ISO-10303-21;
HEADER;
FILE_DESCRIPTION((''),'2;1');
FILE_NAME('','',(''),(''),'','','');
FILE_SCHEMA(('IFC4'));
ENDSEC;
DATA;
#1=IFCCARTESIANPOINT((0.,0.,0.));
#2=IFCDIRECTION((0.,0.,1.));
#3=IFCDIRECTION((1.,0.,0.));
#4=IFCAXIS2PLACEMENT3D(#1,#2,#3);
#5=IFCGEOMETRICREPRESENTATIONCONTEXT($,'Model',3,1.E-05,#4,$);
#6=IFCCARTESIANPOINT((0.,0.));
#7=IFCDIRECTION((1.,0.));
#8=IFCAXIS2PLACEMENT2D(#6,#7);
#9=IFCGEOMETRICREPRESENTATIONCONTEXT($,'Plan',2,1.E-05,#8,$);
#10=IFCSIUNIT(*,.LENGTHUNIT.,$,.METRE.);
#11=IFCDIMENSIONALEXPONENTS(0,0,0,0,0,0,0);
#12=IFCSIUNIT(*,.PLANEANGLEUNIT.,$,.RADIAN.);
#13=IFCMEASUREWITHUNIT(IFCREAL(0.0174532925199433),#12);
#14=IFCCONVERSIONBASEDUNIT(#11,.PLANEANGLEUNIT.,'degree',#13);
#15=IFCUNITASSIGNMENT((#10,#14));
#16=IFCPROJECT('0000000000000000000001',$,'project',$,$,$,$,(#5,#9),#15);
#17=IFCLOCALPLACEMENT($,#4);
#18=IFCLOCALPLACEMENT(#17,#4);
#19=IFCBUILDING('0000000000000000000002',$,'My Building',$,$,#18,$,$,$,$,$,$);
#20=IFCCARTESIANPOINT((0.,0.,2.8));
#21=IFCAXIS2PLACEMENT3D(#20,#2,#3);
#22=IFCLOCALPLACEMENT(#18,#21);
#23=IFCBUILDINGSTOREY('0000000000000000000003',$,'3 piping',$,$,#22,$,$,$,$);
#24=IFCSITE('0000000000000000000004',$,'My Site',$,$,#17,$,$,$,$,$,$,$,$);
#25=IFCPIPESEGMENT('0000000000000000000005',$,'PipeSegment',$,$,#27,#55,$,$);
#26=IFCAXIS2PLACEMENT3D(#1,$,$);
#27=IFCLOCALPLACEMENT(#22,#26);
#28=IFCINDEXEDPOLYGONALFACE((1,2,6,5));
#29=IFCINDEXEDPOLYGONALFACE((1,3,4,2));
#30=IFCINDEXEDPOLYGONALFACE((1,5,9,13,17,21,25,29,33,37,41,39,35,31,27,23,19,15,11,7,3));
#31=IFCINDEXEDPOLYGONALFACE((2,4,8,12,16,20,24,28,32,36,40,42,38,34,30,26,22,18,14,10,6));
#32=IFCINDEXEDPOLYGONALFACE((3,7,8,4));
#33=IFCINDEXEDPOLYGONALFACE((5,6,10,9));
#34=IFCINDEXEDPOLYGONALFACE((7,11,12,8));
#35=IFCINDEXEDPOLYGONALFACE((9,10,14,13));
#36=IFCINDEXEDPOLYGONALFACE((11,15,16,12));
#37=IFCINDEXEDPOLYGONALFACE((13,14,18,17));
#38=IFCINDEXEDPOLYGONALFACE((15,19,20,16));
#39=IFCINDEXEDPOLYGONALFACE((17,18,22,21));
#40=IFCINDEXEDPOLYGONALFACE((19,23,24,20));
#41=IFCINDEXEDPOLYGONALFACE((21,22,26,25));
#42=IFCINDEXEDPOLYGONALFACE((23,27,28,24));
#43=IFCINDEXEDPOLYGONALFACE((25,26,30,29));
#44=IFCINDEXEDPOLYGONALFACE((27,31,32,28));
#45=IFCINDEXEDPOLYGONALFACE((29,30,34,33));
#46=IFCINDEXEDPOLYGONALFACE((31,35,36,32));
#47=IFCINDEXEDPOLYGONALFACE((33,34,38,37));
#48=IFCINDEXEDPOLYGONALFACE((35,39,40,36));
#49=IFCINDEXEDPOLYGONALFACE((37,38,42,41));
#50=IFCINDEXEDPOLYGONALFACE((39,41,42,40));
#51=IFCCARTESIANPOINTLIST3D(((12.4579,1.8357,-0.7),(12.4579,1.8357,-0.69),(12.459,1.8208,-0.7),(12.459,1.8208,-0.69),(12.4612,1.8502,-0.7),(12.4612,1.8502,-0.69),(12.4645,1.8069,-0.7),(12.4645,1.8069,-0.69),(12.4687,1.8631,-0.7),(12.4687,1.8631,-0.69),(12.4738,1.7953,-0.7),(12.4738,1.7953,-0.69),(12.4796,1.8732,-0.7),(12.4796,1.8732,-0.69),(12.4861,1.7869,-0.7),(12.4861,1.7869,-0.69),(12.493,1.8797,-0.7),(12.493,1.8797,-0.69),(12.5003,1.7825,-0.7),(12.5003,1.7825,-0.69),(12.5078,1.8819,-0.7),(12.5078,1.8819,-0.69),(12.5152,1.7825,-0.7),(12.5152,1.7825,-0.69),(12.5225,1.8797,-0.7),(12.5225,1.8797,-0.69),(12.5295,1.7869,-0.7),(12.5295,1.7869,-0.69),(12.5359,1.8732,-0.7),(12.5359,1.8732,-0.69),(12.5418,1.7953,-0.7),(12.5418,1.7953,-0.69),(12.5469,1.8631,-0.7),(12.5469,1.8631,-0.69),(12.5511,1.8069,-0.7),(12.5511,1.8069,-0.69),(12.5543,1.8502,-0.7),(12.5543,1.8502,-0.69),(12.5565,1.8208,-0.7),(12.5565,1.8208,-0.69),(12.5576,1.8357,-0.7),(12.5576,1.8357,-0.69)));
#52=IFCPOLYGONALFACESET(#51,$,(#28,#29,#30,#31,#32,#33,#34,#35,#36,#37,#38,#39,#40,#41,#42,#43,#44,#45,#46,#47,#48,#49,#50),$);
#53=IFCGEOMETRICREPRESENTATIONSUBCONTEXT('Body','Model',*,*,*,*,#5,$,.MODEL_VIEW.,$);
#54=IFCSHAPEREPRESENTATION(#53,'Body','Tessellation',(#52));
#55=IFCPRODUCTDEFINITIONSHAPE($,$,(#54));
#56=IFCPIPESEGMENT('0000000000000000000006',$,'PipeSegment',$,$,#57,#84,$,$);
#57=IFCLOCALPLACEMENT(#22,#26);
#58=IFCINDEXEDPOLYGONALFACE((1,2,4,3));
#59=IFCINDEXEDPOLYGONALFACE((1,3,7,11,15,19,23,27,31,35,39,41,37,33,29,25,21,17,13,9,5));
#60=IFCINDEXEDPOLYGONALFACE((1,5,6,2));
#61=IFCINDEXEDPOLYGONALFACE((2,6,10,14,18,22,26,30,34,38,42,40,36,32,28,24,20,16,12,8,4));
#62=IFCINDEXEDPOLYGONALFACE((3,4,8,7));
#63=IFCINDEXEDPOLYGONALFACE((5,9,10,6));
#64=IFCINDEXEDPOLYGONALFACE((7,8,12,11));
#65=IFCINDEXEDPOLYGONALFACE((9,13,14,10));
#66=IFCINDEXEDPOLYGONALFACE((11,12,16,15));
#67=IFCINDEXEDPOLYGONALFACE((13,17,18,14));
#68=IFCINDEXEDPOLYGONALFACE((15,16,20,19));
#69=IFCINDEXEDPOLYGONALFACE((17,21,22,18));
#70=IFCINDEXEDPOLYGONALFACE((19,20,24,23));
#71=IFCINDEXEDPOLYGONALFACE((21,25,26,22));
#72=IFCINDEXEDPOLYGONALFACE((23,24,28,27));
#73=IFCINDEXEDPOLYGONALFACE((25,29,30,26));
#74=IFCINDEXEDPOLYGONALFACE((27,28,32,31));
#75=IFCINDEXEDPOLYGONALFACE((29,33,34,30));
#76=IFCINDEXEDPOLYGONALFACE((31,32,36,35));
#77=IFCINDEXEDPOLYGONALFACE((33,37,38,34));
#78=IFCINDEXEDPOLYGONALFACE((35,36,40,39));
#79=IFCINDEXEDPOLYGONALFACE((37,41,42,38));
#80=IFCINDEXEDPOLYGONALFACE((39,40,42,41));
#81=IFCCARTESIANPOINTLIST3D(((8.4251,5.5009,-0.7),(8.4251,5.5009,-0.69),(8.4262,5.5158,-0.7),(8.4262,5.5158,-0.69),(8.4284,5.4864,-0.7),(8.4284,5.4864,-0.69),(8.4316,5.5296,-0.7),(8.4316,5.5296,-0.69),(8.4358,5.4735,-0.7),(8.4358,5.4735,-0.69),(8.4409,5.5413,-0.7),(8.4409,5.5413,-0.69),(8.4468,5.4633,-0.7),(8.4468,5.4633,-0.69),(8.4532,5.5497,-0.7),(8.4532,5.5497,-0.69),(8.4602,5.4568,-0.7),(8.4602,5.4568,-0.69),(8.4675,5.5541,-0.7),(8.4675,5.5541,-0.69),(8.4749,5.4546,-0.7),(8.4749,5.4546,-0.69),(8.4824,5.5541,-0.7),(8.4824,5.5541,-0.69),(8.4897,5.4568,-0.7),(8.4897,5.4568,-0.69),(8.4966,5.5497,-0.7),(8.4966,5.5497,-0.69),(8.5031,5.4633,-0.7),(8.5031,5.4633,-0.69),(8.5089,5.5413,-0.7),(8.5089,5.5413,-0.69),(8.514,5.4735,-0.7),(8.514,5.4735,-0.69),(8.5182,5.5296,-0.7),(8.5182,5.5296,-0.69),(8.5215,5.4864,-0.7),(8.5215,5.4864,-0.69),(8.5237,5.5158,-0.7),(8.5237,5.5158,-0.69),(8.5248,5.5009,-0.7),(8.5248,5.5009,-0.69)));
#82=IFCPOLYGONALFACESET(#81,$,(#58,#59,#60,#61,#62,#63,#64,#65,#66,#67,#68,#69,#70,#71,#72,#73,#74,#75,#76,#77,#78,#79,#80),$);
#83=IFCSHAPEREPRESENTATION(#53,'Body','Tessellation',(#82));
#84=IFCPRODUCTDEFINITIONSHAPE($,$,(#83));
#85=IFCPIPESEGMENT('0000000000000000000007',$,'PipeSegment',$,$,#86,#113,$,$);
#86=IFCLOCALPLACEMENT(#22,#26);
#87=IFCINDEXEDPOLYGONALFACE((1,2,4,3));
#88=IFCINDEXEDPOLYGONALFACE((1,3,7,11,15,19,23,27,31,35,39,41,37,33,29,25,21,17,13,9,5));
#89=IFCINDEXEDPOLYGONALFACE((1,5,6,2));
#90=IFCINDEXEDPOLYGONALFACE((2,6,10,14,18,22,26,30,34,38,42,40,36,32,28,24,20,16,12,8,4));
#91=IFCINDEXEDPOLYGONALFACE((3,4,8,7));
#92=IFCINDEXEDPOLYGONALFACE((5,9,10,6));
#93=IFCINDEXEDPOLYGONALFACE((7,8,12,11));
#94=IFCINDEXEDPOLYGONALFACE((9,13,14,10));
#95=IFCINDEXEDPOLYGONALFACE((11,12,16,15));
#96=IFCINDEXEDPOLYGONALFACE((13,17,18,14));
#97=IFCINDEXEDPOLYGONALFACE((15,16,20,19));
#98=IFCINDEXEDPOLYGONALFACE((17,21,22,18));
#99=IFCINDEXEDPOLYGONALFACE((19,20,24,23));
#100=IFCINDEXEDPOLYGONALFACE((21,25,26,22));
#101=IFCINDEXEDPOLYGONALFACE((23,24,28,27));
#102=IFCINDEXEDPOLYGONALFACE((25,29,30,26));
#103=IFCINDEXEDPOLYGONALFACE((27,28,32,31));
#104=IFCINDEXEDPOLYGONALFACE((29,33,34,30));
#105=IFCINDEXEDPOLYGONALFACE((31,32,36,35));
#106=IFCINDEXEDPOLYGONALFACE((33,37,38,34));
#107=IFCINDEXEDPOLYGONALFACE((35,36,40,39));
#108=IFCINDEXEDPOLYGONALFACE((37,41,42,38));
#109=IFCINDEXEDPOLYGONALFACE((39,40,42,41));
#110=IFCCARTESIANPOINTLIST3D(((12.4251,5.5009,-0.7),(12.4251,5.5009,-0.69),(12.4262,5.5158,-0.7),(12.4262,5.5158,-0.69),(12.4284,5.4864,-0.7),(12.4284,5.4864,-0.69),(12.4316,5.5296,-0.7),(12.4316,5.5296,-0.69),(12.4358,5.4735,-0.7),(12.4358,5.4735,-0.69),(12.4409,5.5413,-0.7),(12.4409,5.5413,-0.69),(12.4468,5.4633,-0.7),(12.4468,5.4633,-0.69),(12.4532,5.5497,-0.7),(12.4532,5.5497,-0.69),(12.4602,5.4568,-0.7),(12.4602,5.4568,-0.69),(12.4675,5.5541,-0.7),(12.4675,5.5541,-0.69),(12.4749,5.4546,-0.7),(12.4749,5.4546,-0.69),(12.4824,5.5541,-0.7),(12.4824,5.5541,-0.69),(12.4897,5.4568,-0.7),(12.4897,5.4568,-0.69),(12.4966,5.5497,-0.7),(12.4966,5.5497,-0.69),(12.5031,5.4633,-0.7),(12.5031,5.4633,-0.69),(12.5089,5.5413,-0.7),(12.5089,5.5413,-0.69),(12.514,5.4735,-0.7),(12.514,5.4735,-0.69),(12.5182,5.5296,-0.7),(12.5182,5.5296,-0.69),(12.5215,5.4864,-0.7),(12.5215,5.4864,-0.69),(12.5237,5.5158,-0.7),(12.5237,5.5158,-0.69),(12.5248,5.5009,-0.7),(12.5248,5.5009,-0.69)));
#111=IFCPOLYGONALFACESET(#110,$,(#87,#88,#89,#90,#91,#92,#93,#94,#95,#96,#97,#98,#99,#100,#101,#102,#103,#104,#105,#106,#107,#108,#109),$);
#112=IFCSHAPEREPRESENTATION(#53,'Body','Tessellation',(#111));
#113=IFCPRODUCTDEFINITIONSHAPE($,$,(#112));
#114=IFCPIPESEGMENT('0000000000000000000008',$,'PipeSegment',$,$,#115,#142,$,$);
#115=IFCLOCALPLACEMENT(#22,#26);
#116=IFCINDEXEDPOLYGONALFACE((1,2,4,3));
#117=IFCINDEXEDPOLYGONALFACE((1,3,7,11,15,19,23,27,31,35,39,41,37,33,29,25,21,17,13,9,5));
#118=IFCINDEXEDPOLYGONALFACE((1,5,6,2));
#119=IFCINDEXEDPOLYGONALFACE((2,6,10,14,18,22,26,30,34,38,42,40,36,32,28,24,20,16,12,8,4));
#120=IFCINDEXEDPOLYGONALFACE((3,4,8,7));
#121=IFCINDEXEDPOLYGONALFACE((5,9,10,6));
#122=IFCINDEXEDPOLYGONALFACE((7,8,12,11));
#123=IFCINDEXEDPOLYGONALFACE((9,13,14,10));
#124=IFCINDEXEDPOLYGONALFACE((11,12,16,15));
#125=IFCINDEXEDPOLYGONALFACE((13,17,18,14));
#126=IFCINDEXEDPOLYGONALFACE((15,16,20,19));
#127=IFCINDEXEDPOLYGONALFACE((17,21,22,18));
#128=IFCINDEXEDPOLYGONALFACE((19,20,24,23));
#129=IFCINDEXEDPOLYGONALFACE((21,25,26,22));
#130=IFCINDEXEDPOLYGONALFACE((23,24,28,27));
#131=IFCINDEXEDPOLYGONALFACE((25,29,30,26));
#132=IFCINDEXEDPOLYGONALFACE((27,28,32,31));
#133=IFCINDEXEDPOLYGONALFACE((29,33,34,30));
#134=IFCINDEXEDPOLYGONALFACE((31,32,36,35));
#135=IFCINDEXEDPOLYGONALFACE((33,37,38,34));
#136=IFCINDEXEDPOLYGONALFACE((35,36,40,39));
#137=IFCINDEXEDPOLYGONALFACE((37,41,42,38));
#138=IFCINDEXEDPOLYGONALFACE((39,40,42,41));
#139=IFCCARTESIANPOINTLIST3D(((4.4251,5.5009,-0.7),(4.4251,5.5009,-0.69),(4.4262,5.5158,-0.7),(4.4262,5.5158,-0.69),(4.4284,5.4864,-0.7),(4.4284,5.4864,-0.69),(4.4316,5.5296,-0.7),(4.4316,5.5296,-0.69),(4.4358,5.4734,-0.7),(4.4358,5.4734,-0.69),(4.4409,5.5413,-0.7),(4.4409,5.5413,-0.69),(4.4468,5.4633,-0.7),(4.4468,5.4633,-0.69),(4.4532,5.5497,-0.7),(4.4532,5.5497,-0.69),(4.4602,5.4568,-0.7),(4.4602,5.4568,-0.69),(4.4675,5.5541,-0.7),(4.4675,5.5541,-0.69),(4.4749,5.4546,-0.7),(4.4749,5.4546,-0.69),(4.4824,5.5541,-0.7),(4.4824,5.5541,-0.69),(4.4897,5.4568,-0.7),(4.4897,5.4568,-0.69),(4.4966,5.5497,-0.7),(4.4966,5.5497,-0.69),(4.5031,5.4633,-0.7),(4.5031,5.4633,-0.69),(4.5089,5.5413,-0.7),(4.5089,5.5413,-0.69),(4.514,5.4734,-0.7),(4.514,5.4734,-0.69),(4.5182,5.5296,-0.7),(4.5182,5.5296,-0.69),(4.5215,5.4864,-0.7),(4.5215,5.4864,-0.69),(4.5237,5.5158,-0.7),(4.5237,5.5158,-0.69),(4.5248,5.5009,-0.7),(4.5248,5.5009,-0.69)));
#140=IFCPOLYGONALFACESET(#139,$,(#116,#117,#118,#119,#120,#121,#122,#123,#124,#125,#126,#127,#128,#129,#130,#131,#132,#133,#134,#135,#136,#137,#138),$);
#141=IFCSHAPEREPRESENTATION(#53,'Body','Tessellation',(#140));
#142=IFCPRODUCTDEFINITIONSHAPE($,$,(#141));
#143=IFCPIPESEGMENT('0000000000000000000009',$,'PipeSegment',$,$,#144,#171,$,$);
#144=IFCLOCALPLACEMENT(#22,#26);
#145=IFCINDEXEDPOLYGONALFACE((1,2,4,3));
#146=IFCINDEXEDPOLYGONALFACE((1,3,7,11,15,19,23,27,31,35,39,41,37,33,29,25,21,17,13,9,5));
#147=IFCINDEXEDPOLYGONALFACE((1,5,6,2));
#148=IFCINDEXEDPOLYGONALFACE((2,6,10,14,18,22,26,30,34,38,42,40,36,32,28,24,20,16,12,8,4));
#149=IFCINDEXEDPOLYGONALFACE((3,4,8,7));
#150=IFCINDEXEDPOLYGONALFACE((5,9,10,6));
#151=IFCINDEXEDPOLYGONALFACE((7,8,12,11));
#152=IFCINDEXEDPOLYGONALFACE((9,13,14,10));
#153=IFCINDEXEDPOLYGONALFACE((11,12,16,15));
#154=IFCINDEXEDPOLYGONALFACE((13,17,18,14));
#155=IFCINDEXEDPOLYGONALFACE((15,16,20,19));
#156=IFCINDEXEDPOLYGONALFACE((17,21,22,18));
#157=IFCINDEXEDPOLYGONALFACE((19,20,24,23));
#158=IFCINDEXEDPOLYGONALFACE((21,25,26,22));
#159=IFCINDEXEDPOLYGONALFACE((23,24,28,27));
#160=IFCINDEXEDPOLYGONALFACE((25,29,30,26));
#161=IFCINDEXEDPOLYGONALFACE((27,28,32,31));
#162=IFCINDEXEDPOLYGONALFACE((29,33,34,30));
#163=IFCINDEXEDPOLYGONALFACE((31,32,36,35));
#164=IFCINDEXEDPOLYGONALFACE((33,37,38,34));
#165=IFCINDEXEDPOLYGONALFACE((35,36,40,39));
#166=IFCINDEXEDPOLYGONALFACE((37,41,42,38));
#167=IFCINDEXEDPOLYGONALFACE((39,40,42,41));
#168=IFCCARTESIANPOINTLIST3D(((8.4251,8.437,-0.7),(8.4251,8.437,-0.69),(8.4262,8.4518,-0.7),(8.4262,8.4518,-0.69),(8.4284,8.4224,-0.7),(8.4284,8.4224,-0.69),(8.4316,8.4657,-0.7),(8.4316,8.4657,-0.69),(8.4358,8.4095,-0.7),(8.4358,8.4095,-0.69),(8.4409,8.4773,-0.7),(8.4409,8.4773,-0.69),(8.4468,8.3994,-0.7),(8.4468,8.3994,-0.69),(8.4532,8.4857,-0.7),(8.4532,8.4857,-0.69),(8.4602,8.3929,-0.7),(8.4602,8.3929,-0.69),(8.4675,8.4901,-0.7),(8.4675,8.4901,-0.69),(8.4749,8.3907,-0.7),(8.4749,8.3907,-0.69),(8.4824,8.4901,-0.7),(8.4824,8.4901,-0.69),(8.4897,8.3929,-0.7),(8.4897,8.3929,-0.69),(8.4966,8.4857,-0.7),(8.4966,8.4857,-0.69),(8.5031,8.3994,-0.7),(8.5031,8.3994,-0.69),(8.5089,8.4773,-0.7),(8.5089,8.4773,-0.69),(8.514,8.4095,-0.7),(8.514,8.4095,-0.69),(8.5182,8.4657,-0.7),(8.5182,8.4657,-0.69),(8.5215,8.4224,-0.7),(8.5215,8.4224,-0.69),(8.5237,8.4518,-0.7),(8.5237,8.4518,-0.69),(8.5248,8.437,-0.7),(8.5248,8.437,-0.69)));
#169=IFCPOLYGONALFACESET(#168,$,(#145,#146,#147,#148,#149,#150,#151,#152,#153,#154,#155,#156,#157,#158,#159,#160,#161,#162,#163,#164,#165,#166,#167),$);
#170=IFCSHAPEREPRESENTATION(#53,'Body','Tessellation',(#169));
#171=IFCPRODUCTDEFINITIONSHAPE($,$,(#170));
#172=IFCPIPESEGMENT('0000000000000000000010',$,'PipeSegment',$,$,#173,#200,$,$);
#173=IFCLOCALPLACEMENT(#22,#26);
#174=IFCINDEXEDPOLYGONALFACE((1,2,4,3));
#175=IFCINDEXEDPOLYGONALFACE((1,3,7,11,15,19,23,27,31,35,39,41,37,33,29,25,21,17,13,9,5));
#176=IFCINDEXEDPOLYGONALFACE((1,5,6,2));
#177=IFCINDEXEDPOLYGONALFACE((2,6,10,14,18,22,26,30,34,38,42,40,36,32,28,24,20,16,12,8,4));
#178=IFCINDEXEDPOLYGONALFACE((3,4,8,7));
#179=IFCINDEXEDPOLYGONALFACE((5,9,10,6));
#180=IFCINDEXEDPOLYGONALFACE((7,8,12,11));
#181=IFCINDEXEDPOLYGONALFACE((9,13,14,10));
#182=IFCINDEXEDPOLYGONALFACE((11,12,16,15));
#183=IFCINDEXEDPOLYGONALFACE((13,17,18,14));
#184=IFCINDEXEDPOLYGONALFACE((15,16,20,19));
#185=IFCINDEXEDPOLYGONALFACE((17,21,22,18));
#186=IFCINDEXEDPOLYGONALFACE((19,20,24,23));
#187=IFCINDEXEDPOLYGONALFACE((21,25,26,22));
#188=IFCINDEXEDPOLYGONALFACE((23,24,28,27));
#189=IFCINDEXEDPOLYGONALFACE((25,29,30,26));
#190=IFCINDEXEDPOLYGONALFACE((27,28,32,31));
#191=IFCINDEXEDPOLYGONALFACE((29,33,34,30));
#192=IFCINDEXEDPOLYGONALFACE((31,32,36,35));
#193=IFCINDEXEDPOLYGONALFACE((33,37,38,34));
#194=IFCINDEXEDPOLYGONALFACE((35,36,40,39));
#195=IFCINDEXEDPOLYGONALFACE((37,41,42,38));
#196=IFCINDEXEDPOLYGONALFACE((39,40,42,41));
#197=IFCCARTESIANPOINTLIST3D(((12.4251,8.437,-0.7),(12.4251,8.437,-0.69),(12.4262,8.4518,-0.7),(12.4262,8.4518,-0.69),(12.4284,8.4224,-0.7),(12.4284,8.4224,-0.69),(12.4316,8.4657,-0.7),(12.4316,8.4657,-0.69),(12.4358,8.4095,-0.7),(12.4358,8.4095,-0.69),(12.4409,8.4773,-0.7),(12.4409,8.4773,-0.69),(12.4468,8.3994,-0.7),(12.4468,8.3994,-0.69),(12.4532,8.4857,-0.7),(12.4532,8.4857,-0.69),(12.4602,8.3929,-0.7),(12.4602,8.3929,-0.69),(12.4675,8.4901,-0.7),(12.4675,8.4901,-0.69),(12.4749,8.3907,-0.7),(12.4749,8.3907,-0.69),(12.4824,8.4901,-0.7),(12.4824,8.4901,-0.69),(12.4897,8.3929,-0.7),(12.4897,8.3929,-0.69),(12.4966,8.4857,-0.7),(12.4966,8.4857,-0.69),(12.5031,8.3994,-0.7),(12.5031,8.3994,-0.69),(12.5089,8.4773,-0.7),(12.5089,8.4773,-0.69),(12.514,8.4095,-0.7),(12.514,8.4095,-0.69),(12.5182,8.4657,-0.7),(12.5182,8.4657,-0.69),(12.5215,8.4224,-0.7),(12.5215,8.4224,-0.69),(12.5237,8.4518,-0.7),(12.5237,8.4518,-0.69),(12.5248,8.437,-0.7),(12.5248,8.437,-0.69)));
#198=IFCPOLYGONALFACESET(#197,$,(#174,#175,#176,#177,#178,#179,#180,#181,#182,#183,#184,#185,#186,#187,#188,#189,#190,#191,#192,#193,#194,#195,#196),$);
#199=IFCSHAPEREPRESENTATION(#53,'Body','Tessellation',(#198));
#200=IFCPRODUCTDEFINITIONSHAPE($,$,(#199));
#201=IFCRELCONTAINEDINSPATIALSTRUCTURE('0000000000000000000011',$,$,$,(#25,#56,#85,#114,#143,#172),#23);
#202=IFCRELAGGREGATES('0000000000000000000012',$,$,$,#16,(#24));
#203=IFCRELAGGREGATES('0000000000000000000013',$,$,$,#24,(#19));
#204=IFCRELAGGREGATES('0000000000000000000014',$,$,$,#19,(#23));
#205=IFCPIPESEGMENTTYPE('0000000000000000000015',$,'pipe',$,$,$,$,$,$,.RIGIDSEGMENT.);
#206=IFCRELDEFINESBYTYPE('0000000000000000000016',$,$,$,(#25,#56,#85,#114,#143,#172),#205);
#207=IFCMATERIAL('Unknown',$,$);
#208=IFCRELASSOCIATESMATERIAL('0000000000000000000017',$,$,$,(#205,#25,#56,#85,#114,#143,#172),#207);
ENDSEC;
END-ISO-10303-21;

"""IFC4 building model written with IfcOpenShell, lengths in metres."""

from ifc_helpers import new_model, entity, si_unit, converted_unit, frame, origin_with_axes, origin_2d_with_axis, place, context, subcontext, project, spatial, circle, extrude, material, material_profile, profile_set, profile_usage, type_object, element, save


model = new_model("IFC4")

# Units and contexts
model_context = context("Model", 3, precision=1e-05, world=origin_with_axes())
plan_context = context("Plan", 2, precision=1e-05, world=origin_2d_with_axis())
body_context = subcontext(model_context, "Body", "Model", "MODEL_VIEW")
ifc_project = project(units=[si_unit("LENGTHUNIT", "METRE"), converted_unit("PLANEANGLEUNIT", "degree", entity("IfcReal", 0.0174532925199433), si_unit("PLANEANGLEUNIT", "RADIAN"), dimensions=[0, 0, 0, 0, 0, 0, 0])], contexts=[model_context, plan_context])

# Site, building, storey
site_placement = place(None, origin_with_axes())
site = spatial("IfcSite", under=ifc_project, at=site_placement, Name="My Site")
building_placement = place(site_placement, origin_with_axes())
building = spatial("IfcBuilding", under=site, at=building_placement, Name="My Building")
storey_placement = place(building_placement, frame((0.0, 0.0, 2.8), z_axis=(0.0, 0.0, 1.0), x_axis=(1.0, 0.0, 0.0)))
storey = spatial("IfcBuildingStorey", under=building, at=storey_placement, Name="3 piping")

# Pipe segments
ifc_material = material(Name="Unknown")
ifc_material_profile_1 = material_profile(ifc_material, circle(Radius=0.05))
ifc_profile_set_1 = profile_set([ifc_material_profile_1])
pipe_segment_type = type_object("IfcPipeSegmentType", Name="pipe", PredefinedType="RIGIDSEGMENT", material=ifc_profile_set_1)
ifc_profile_usage_1 = profile_usage(ifc_profile_set_1, cardinal=2)
pipe_segment_1_placement = place(storey_placement, frame((12.4578, 1.8319, -0.69), z_axis=(0.0, 0.0, -1.0), x_axis=(0.0, 1.0, 0.0)))
element("IfcPipeSegment", 1, at=pipe_segment_1_placement, inside=storey, type_object=pipe_segment_type, material=ifc_profile_usage_1, Name="PipeSegment", context=body_context, shape_type="SweptSolid", body=[
    extrude(circle(Radius=0.05), frame((0.0, 0.05, 0.0), z_axis=(0.0, 0.0, 1.0), x_axis=(1.0, 0.0, 0.0)), (0.0, 0.0, 1.0), 0.01),
])
ifc_profile_usage_2 = profile_usage(ifc_profile_set_1, cardinal=2)
pipe_segment_2_placement = place(storey_placement, frame((8.5249, 5.5046, -0.69), z_axis=(0.0, 0.0, -1.0), x_axis=(0.0, -1.0, 0.0)))
element("IfcPipeSegment", 2, at=pipe_segment_2_placement, inside=storey, type_object=pipe_segment_type, material=ifc_profile_usage_2, Name="PipeSegment", context=body_context, shape_type="SweptSolid", body=[
    extrude(circle(Radius=0.05), frame((0.0, 0.05, 0.0), z_axis=(0.0, 0.0, 1.0), x_axis=(1.0, 0.0, 0.0)), (0.0, 0.0, 1.0), 0.01),
])
ifc_profile_usage_3 = profile_usage(ifc_profile_set_1, cardinal=2)
pipe_segment_3_placement = place(storey_placement, frame((12.5249, 5.5046, -0.69), z_axis=(0.0, 0.0, -1.0), x_axis=(0.0, -1.0, 0.0)))
element("IfcPipeSegment", 3, at=pipe_segment_3_placement, inside=storey, type_object=pipe_segment_type, material=ifc_profile_usage_3, Name="PipeSegment", context=body_context, shape_type="SweptSolid", body=[
    extrude(circle(Radius=0.05), frame((0.0, 0.05, 0.0), z_axis=(0.0, 0.0, 1.0), x_axis=(1.0, 0.0, 0.0)), (0.0, 0.0, 1.0), 0.01),
])
ifc_profile_usage_4 = profile_usage(ifc_profile_set_1, cardinal=2)
pipe_segment_4_placement = place(storey_placement, frame((4.5249, 5.5046, -0.69), z_axis=(0.0, 0.0, -1.0), x_axis=(0.0, -1.0, 0.0)))
element("IfcPipeSegment", 4, at=pipe_segment_4_placement, inside=storey, type_object=pipe_segment_type, material=ifc_profile_usage_4, Name="PipeSegment", context=body_context, shape_type="SweptSolid", body=[
    extrude(circle(Radius=0.05), frame((0.0, 0.05, 0.0), z_axis=(0.0, 0.0, 1.0), x_axis=(1.0, 0.0, 0.0)), (0.0, 0.0, 1.0), 0.01),
])
ifc_profile_usage_5 = profile_usage(ifc_profile_set_1, cardinal=2)
pipe_segment_5_placement = place(storey_placement, frame((8.5249, 8.4407, -0.69), z_axis=(0.0, 0.0, -1.0), x_axis=(0.0, -1.0, 0.0)))
element("IfcPipeSegment", 5, at=pipe_segment_5_placement, inside=storey, type_object=pipe_segment_type, material=ifc_profile_usage_5, Name="PipeSegment", context=body_context, shape_type="SweptSolid", body=[
    extrude(circle(Radius=0.05), frame((0.0, 0.05, 0.0), z_axis=(0.0, 0.0, 1.0), x_axis=(1.0, 0.0, 0.0)), (0.0, 0.0, 1.0), 0.01),
])
ifc_profile_usage_6 = profile_usage(ifc_profile_set_1, cardinal=2)
pipe_segment_6_placement = place(storey_placement, frame((12.5249, 8.4407, -0.69), z_axis=(0.0, 0.0, -1.0), x_axis=(0.0, -1.0, 0.0)))
element("IfcPipeSegment", 6, at=pipe_segment_6_placement, inside=storey, type_object=pipe_segment_type, material=ifc_profile_usage_6, Name="PipeSegment", context=body_context, shape_type="SweptSolid", body=[
    extrude(circle(Radius=0.05), frame((0.0, 0.05, 0.0), z_axis=(0.0, 0.0, 1.0), x_axis=(1.0, 0.0, 0.0)), (0.0, 0.0, 1.0), 0.01),
])

save(model, "model.ifc")
